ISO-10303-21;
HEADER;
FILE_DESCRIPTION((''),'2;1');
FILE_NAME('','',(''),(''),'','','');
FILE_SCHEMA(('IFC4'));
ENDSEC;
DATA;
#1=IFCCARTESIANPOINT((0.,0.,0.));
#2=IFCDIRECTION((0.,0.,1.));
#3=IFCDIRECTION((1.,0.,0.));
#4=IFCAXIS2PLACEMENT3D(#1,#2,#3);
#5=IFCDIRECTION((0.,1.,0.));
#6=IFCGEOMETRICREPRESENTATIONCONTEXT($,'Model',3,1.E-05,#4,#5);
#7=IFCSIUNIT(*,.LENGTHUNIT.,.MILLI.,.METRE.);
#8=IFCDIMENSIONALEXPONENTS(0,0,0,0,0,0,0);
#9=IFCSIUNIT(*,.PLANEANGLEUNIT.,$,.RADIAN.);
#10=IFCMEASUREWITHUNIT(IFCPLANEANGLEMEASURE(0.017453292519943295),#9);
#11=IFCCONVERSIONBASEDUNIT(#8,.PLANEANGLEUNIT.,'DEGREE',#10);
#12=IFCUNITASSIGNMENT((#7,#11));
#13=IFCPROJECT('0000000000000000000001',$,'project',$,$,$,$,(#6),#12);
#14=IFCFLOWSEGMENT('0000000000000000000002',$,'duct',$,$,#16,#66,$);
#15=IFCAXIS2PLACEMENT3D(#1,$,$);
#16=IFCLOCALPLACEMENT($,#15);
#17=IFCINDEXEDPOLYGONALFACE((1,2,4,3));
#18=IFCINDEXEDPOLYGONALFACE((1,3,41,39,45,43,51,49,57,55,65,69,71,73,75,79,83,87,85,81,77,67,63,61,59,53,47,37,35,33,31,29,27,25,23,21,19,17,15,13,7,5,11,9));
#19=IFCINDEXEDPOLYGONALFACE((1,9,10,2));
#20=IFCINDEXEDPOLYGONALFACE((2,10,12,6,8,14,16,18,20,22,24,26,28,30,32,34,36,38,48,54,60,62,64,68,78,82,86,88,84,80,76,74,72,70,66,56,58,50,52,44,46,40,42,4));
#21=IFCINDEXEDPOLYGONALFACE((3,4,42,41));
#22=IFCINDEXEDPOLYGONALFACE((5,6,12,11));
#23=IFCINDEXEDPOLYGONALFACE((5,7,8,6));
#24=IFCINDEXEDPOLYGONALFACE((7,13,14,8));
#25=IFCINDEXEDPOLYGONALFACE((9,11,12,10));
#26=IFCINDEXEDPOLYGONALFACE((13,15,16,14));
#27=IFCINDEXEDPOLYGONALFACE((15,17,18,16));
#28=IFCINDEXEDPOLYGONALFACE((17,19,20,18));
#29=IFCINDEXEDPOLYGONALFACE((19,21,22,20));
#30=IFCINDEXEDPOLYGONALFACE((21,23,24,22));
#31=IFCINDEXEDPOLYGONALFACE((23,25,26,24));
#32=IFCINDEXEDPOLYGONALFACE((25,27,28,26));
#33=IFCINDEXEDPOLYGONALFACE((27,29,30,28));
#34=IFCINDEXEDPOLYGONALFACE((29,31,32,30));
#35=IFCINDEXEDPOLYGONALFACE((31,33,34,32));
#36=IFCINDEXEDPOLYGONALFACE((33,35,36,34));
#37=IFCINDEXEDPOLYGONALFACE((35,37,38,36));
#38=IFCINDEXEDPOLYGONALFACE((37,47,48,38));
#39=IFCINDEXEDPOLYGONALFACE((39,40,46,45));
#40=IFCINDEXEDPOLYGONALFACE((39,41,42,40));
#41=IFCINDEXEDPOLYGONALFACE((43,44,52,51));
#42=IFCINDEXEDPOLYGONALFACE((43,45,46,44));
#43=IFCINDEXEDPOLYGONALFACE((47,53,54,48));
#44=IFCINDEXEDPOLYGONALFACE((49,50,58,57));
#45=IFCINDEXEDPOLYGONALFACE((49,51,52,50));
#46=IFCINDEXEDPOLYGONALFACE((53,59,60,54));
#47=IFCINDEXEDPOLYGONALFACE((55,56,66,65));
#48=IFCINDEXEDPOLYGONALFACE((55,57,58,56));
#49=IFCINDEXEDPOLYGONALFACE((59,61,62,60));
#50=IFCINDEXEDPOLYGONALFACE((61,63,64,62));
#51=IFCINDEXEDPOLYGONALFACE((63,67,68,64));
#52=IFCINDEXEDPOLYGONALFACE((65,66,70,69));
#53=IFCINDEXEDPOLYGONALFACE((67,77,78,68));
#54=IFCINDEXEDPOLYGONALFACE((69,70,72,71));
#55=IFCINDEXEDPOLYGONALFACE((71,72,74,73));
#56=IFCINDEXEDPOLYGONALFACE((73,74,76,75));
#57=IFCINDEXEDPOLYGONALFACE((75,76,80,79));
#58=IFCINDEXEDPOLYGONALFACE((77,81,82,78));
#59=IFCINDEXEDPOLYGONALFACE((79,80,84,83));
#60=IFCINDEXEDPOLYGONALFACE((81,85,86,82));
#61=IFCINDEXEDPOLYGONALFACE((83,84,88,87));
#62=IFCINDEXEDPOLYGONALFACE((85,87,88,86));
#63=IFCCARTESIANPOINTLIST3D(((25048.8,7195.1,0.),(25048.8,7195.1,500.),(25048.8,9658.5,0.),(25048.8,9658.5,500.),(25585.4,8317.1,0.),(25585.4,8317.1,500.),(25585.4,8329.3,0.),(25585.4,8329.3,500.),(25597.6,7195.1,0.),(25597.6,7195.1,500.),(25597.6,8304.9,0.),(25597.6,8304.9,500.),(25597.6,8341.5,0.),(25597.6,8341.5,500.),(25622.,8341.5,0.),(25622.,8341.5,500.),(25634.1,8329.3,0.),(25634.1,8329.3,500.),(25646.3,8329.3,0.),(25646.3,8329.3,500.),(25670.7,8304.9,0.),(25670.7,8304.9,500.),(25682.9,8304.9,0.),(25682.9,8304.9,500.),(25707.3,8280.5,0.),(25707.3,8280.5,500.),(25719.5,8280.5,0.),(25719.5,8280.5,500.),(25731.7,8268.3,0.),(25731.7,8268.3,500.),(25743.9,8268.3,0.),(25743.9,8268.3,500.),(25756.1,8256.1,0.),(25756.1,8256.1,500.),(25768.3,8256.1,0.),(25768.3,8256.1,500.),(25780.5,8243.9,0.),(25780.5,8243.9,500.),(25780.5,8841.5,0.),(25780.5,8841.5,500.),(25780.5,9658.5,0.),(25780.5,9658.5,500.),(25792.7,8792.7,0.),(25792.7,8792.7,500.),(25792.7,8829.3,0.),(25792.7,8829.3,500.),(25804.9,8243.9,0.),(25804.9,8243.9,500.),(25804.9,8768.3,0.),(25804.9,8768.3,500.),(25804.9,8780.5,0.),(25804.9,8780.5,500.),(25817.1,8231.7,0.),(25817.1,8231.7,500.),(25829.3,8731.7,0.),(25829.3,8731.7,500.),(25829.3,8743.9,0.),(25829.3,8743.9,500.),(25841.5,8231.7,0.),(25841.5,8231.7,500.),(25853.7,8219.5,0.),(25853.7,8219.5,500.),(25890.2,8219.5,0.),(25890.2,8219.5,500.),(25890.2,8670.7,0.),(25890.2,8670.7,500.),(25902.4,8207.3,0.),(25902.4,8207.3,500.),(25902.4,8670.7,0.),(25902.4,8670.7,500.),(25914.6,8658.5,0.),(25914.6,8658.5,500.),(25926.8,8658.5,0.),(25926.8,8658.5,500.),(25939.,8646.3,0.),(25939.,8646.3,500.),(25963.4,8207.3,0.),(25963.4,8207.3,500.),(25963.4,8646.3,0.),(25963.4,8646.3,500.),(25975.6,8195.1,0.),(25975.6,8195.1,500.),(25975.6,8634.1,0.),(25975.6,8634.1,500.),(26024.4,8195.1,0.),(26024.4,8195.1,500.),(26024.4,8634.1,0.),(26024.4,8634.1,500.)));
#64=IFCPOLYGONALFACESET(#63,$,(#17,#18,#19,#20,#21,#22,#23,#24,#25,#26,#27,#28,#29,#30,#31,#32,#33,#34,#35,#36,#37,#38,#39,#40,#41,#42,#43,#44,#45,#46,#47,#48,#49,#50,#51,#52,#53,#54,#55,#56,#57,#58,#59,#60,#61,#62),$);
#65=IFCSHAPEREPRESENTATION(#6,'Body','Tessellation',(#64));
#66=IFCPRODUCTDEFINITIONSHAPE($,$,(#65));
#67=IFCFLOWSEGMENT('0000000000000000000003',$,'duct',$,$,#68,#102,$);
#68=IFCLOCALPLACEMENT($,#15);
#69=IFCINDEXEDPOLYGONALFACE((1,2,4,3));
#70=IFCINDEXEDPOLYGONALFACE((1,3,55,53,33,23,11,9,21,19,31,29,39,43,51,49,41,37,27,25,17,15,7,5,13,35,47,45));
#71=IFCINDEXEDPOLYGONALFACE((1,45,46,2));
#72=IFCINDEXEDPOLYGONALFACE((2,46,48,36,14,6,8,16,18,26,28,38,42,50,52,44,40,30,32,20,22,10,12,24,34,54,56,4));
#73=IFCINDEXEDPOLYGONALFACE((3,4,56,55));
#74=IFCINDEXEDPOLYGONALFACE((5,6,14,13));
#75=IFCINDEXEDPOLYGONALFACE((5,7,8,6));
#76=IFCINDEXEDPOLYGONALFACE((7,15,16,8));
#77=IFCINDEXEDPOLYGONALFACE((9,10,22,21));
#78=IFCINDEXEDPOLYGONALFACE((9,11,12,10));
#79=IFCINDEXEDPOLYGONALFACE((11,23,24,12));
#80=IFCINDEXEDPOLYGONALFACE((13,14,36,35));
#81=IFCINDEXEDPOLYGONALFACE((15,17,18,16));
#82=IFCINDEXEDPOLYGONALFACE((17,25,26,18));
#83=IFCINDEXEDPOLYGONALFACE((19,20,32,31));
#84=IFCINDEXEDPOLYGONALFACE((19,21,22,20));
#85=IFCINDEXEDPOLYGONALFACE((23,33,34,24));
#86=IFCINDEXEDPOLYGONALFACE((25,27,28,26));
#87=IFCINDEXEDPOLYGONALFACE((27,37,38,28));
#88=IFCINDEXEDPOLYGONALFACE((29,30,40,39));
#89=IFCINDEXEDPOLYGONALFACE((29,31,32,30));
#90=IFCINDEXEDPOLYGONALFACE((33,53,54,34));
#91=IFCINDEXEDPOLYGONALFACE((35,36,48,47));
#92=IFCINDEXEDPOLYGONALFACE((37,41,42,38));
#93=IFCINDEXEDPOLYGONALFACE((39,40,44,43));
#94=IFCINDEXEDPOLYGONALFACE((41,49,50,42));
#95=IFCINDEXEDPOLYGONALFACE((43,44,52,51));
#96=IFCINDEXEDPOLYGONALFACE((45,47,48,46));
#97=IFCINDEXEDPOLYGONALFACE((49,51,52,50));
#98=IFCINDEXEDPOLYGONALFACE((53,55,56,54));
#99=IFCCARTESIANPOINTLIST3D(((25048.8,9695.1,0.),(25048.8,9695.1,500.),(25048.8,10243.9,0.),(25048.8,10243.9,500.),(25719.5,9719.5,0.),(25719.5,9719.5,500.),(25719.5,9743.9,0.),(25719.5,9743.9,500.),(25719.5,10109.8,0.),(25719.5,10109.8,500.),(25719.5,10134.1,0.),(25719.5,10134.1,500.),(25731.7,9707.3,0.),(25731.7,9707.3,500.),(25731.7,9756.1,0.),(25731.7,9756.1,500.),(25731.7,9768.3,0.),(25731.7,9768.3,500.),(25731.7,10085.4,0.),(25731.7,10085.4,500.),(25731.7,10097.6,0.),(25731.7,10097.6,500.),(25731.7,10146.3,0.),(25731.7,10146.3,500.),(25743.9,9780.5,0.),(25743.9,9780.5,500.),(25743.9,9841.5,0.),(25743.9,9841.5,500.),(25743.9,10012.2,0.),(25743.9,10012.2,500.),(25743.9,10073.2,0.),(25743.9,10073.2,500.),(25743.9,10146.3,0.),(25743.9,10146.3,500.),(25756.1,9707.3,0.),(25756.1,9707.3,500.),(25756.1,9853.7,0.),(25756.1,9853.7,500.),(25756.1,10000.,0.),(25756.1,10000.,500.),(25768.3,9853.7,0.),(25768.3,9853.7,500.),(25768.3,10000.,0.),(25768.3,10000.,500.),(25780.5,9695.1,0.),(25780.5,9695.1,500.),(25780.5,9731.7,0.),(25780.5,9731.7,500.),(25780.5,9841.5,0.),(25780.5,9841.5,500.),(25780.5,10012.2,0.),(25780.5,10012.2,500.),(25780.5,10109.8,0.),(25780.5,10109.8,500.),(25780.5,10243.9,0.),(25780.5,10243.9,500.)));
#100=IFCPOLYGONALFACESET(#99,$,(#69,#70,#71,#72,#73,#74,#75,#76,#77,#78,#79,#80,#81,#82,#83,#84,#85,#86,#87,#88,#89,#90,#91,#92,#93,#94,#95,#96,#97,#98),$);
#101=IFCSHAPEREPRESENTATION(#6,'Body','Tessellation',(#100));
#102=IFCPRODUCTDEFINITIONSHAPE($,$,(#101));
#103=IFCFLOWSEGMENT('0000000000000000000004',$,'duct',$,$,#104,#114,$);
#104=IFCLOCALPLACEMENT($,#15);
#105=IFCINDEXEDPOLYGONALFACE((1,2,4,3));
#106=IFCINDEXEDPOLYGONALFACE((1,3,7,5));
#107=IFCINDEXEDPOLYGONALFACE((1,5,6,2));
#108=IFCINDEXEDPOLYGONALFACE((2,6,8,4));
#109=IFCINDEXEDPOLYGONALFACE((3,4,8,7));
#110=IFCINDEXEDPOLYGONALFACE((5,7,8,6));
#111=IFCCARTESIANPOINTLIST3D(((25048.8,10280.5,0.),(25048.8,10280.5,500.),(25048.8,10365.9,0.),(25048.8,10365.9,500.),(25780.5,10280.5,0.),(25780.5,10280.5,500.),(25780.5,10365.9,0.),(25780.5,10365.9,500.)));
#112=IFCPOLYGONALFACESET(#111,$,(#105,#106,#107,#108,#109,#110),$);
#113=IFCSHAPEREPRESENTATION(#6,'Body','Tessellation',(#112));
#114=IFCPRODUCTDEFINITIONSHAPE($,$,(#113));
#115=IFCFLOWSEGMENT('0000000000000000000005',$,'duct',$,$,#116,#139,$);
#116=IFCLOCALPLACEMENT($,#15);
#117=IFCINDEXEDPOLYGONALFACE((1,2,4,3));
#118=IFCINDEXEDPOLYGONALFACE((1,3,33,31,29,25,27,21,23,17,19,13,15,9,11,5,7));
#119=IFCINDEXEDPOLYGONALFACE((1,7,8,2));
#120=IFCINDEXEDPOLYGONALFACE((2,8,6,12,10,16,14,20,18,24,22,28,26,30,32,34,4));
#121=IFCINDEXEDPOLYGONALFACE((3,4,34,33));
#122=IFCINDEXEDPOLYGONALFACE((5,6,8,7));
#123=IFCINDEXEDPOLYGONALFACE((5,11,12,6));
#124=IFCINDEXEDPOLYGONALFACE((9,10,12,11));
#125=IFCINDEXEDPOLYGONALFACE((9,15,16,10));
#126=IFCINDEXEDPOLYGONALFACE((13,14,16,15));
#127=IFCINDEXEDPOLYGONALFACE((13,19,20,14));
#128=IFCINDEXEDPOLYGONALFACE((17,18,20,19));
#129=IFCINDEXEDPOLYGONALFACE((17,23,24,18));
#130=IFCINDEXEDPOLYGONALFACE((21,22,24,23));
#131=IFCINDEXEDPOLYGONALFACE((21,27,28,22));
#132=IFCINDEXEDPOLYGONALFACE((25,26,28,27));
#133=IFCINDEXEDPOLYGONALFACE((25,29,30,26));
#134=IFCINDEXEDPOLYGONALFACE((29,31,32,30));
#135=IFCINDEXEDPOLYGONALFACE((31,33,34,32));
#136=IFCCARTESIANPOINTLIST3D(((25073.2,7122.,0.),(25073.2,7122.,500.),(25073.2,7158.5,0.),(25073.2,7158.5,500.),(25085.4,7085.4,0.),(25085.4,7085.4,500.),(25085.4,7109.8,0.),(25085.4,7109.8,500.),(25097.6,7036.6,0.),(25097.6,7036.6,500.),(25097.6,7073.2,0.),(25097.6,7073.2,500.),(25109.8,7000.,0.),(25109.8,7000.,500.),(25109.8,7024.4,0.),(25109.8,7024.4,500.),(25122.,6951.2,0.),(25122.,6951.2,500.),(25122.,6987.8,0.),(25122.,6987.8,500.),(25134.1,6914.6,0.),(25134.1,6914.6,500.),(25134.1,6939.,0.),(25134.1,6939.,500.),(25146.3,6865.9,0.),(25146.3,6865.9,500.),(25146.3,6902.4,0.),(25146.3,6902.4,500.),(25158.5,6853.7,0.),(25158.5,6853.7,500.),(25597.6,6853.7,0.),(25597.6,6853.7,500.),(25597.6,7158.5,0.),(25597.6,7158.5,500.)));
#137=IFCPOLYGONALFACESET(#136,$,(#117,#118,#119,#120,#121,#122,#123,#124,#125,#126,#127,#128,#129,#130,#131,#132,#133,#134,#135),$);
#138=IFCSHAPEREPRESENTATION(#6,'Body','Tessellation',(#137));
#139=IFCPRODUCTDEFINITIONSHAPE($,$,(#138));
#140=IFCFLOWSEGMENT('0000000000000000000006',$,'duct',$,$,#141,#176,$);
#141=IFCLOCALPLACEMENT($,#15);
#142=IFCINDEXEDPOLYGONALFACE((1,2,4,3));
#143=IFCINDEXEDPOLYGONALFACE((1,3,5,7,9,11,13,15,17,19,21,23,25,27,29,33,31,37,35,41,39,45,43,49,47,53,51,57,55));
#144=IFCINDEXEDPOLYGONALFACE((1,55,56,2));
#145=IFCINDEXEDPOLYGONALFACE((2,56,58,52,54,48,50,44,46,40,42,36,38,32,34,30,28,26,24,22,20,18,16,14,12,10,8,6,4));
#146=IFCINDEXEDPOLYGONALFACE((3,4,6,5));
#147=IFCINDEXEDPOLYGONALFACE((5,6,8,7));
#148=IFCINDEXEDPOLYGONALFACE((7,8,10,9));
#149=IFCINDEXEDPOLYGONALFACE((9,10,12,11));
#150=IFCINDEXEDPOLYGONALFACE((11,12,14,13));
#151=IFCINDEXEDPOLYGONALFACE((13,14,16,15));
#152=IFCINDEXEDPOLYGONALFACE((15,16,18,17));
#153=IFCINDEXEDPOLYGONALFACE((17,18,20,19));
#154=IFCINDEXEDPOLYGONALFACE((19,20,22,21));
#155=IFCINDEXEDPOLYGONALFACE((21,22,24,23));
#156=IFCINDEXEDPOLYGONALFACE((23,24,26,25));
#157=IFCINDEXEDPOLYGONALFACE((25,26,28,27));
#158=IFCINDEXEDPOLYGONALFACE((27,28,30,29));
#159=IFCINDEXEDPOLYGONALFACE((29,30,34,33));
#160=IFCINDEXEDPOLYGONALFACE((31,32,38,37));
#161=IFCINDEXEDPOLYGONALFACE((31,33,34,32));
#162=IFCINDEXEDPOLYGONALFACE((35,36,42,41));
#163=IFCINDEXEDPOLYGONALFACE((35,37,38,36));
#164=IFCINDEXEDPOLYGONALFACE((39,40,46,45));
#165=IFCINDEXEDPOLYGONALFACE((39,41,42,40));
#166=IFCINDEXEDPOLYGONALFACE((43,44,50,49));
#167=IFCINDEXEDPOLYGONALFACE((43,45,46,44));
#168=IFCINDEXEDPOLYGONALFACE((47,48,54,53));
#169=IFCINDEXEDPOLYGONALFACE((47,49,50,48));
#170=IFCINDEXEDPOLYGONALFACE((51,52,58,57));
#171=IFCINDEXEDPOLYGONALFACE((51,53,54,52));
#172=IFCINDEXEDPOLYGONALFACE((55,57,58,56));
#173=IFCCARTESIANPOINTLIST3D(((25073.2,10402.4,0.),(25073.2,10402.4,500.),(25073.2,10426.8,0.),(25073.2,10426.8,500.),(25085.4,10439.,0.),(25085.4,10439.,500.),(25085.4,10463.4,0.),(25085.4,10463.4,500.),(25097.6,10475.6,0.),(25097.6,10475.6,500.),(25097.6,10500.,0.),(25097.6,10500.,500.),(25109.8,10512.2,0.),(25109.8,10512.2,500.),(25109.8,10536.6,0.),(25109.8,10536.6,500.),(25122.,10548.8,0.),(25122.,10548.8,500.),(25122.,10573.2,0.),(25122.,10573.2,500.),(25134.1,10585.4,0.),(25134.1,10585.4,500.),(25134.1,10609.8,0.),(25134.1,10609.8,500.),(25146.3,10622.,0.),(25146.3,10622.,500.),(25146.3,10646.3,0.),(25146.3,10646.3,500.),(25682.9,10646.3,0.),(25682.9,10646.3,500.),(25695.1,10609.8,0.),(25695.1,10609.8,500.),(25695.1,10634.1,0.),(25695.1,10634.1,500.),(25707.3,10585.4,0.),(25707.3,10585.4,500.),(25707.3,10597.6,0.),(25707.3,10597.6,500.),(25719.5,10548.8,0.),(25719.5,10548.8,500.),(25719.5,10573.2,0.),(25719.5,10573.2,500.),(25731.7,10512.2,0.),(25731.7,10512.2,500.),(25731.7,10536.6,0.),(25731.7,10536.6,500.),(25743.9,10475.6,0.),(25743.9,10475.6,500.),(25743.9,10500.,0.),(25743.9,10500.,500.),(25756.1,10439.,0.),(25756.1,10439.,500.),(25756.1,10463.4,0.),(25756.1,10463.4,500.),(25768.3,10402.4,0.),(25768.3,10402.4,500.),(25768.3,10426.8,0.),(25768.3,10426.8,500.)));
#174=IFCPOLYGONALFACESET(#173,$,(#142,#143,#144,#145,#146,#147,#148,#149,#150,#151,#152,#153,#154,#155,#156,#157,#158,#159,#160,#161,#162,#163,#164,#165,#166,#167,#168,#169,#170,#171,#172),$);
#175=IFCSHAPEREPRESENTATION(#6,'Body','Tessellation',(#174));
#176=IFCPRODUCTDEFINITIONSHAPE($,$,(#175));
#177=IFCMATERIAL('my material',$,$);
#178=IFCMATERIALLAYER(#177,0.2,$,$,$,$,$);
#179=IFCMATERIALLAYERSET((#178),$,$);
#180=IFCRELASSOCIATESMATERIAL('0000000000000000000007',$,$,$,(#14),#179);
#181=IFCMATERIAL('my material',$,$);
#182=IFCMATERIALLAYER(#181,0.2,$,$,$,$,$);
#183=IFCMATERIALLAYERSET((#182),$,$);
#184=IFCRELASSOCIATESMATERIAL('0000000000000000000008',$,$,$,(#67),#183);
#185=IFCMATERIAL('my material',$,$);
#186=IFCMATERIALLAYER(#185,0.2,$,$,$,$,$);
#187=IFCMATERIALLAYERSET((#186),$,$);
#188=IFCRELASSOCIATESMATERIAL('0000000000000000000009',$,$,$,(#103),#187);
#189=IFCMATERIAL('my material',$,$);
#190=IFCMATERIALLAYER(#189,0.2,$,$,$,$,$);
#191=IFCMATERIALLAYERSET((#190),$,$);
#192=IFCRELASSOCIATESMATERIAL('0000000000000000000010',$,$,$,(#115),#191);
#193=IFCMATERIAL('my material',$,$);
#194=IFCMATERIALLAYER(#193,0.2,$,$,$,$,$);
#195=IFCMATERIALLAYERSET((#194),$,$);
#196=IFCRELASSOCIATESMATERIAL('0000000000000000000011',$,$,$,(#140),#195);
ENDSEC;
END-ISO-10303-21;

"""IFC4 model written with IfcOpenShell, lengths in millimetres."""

from ifc_helpers import new_model, entity, si_unit, converted_unit, direction, origin_with_axes, place, context, project, polyline, outline, extrude, material, layer, layer_set, layer_usage, element, save


model = new_model("IFC4")

# Units and contexts
model_context = context("Model", 3, precision=1e-05, world=origin_with_axes(), true_north=direction((0.0, 1.0, 0.0)))
ifc_project = project(units=[si_unit("LENGTHUNIT", "METRE", prefix="MILLI"), converted_unit("PLANEANGLEUNIT", "DEGREE", entity("IfcPlaneAngleMeasure", 0.017453292519943295), si_unit("PLANEANGLEUNIT", "RADIAN"), dimensions=[0, 0, 0, 0, 0, 0, 0])], contexts=[model_context])

# Flow segments
ifc_material_1 = material(Name="my material")
ifc_layer_1 = layer(ifc_material_1, 0.2)
ifc_layer_set_1 = layer_set([ifc_layer_1])
ifc_layer_usage_1 = layer_usage(ifc_layer_set_1, "AXIS2", "POSITIVE", -0.1)
flow_segment_1_placement = place(None, origin_with_axes())
element("IfcFlowSegment", 1, at=flow_segment_1_placement, material=ifc_layer_usage_1, Name="duct", context=model_context, shape_type="SweptSolid", body=[
    extrude(outline(polyline([(25048.8, 7195.1), (25597.6, 7195.1), (25597.6, 8304.9), (25585.4, 8317.1), (25585.4, 8329.3), (25597.6, 8341.5), (25622.0, 8341.5), (25634.1, 8329.3), (25646.3, 8329.3), (25670.7, 8304.9), (25682.9, 8304.9), (25707.3, 8280.5), (25719.5, 8280.5), (25731.7, 8268.3), (25743.9, 8268.3), (25756.1, 8256.1), (25768.3, 8256.1), (25780.5, 8243.9), (25804.9, 8243.9), (25817.1, 8231.7), (25841.5, 8231.7), (25853.7, 8219.5), (25890.2, 8219.5), (25902.4, 8207.3), (25963.4, 8207.3), (25975.6, 8195.1), (26024.4, 8195.1), (26024.4, 8634.1), (25975.6, 8634.1), (25963.4, 8646.3), (25939.0, 8646.3), (25926.8, 8658.5), (25914.6, 8658.5), (25902.4, 8670.7), (25890.2, 8670.7), (25829.3, 8731.7), (25829.3, 8743.9), (25804.9, 8768.3), (25804.9, 8780.5), (25792.7, 8792.7), (25792.7, 8829.3), (25780.5, 8841.5), (25780.5, 9658.5), (25048.8, 9658.5), (25048.8, 7195.1)])), origin_with_axes(), (0.0, 0.0, 1.0), 500.0),
])
ifc_material_2 = material(Name="my material")
ifc_layer_2 = layer(ifc_material_2, 0.2)
ifc_layer_set_2 = layer_set([ifc_layer_2])
ifc_layer_usage_2 = layer_usage(ifc_layer_set_2, "AXIS2", "POSITIVE", -0.1)
flow_segment_2_placement = place(None, origin_with_axes())
element("IfcFlowSegment", 2, at=flow_segment_2_placement, material=ifc_layer_usage_2, Name="duct", context=model_context, shape_type="SweptSolid", body=[
    extrude(outline(polyline([(25048.8, 9695.1), (25780.5, 9695.1), (25780.5, 9743.9), (25780.5, 9731.7), (25756.1, 9707.3), (25731.7, 9707.3), (25719.5, 9719.5), (25719.5, 9743.9), (25731.7, 9756.1), (25731.7, 9768.3), (25743.9, 9780.5), (25743.9, 9841.5), (25756.1, 9853.7), (25768.3, 9853.7), (25780.5, 9841.5), (25780.5, 9792.7), (25780.5, 10061.0), (25780.5, 10012.2), (25768.3, 10000.0), (25756.1, 10000.0), (25743.9, 10012.2), (25743.9, 10073.2), (25731.7, 10085.4), (25731.7, 10097.6), (25719.5, 10109.8), (25719.5, 10134.1), (25731.7, 10146.3), (25743.9, 10146.3), (25780.5, 10109.8), (25780.5, 10097.6), (25780.5, 10243.9), (25048.8, 10243.9), (25048.8, 9695.1)])), origin_with_axes(), (0.0, 0.0, 1.0), 500.0),
])
ifc_material_3 = material(Name="my material")
ifc_layer_3 = layer(ifc_material_3, 0.2)
ifc_layer_set_3 = layer_set([ifc_layer_3])
ifc_layer_usage_3 = layer_usage(ifc_layer_set_3, "AXIS2", "POSITIVE", -0.1)
flow_segment_3_placement = place(None, origin_with_axes())
element("IfcFlowSegment", 3, at=flow_segment_3_placement, material=ifc_layer_usage_3, Name="duct", context=model_context, shape_type="SweptSolid", body=[
    extrude(outline(polyline([(25048.8, 10280.5), (25780.5, 10280.5), (25780.5, 10365.9), (25048.8, 10365.9), (25048.8, 10280.5)])), origin_with_axes(), (0.0, 0.0, 1.0), 500.0),
])
ifc_material_4 = material(Name="my material")
ifc_layer_4 = layer(ifc_material_4, 0.2)
ifc_layer_set_4 = layer_set([ifc_layer_4])
ifc_layer_usage_4 = layer_usage(ifc_layer_set_4, "AXIS2", "POSITIVE", -0.1)
flow_segment_4_placement = place(None, origin_with_axes())
element("IfcFlowSegment", 4, at=flow_segment_4_placement, material=ifc_layer_usage_4, Name="duct", context=model_context, shape_type="SweptSolid", body=[
    extrude(outline(polyline([(25073.2, 7122.0), (25085.4, 7109.8), (25085.4, 7085.4), (25097.6, 7073.2), (25097.6, 7036.6), (25109.8, 7024.4), (25109.8, 7000.0), (25122.0, 6987.8), (25122.0, 6951.2), (25134.1, 6939.0), (25134.1, 6914.6), (25146.3, 6902.4), (25146.3, 6865.9), (25158.5, 6853.7), (25597.6, 6853.7), (25597.6, 7158.5), (25073.2, 7158.5), (25073.2, 7122.0)])), origin_with_axes(), (0.0, 0.0, 1.0), 500.0),
])
ifc_material_5 = material(Name="my material")
ifc_layer_5 = layer(ifc_material_5, 0.2)
ifc_layer_set_5 = layer_set([ifc_layer_5])
ifc_layer_usage_5 = layer_usage(ifc_layer_set_5, "AXIS2", "POSITIVE", -0.1)
flow_segment_5_placement = place(None, origin_with_axes())
element("IfcFlowSegment", 5, at=flow_segment_5_placement, material=ifc_layer_usage_5, Name="duct", context=model_context, shape_type="SweptSolid", body=[
    extrude(outline(polyline([(25073.2, 10402.4), (25768.3, 10402.4), (25768.3, 10426.8), (25756.1, 10439.0), (25756.1, 10463.4), (25743.9, 10475.6), (25743.9, 10500.0), (25731.7, 10512.2), (25731.7, 10536.6), (25719.5, 10548.8), (25719.5, 10573.2), (25707.3, 10585.4), (25707.3, 10597.6), (25695.1, 10609.8), (25695.1, 10634.1), (25682.9, 10646.3), (25146.3, 10646.3), (25146.3, 10622.0), (25134.1, 10609.8), (25134.1, 10585.4), (25122.0, 10573.2), (25122.0, 10548.8), (25109.8, 10536.6), (25109.8, 10512.2), (25097.6, 10500.0), (25097.6, 10475.6), (25085.4, 10463.4), (25085.4, 10439.0), (25073.2, 10426.8), (25073.2, 10402.4)])), origin_with_axes(), (0.0, 0.0, 1.0), 500.0),
])

save(model, "model.ifc")
